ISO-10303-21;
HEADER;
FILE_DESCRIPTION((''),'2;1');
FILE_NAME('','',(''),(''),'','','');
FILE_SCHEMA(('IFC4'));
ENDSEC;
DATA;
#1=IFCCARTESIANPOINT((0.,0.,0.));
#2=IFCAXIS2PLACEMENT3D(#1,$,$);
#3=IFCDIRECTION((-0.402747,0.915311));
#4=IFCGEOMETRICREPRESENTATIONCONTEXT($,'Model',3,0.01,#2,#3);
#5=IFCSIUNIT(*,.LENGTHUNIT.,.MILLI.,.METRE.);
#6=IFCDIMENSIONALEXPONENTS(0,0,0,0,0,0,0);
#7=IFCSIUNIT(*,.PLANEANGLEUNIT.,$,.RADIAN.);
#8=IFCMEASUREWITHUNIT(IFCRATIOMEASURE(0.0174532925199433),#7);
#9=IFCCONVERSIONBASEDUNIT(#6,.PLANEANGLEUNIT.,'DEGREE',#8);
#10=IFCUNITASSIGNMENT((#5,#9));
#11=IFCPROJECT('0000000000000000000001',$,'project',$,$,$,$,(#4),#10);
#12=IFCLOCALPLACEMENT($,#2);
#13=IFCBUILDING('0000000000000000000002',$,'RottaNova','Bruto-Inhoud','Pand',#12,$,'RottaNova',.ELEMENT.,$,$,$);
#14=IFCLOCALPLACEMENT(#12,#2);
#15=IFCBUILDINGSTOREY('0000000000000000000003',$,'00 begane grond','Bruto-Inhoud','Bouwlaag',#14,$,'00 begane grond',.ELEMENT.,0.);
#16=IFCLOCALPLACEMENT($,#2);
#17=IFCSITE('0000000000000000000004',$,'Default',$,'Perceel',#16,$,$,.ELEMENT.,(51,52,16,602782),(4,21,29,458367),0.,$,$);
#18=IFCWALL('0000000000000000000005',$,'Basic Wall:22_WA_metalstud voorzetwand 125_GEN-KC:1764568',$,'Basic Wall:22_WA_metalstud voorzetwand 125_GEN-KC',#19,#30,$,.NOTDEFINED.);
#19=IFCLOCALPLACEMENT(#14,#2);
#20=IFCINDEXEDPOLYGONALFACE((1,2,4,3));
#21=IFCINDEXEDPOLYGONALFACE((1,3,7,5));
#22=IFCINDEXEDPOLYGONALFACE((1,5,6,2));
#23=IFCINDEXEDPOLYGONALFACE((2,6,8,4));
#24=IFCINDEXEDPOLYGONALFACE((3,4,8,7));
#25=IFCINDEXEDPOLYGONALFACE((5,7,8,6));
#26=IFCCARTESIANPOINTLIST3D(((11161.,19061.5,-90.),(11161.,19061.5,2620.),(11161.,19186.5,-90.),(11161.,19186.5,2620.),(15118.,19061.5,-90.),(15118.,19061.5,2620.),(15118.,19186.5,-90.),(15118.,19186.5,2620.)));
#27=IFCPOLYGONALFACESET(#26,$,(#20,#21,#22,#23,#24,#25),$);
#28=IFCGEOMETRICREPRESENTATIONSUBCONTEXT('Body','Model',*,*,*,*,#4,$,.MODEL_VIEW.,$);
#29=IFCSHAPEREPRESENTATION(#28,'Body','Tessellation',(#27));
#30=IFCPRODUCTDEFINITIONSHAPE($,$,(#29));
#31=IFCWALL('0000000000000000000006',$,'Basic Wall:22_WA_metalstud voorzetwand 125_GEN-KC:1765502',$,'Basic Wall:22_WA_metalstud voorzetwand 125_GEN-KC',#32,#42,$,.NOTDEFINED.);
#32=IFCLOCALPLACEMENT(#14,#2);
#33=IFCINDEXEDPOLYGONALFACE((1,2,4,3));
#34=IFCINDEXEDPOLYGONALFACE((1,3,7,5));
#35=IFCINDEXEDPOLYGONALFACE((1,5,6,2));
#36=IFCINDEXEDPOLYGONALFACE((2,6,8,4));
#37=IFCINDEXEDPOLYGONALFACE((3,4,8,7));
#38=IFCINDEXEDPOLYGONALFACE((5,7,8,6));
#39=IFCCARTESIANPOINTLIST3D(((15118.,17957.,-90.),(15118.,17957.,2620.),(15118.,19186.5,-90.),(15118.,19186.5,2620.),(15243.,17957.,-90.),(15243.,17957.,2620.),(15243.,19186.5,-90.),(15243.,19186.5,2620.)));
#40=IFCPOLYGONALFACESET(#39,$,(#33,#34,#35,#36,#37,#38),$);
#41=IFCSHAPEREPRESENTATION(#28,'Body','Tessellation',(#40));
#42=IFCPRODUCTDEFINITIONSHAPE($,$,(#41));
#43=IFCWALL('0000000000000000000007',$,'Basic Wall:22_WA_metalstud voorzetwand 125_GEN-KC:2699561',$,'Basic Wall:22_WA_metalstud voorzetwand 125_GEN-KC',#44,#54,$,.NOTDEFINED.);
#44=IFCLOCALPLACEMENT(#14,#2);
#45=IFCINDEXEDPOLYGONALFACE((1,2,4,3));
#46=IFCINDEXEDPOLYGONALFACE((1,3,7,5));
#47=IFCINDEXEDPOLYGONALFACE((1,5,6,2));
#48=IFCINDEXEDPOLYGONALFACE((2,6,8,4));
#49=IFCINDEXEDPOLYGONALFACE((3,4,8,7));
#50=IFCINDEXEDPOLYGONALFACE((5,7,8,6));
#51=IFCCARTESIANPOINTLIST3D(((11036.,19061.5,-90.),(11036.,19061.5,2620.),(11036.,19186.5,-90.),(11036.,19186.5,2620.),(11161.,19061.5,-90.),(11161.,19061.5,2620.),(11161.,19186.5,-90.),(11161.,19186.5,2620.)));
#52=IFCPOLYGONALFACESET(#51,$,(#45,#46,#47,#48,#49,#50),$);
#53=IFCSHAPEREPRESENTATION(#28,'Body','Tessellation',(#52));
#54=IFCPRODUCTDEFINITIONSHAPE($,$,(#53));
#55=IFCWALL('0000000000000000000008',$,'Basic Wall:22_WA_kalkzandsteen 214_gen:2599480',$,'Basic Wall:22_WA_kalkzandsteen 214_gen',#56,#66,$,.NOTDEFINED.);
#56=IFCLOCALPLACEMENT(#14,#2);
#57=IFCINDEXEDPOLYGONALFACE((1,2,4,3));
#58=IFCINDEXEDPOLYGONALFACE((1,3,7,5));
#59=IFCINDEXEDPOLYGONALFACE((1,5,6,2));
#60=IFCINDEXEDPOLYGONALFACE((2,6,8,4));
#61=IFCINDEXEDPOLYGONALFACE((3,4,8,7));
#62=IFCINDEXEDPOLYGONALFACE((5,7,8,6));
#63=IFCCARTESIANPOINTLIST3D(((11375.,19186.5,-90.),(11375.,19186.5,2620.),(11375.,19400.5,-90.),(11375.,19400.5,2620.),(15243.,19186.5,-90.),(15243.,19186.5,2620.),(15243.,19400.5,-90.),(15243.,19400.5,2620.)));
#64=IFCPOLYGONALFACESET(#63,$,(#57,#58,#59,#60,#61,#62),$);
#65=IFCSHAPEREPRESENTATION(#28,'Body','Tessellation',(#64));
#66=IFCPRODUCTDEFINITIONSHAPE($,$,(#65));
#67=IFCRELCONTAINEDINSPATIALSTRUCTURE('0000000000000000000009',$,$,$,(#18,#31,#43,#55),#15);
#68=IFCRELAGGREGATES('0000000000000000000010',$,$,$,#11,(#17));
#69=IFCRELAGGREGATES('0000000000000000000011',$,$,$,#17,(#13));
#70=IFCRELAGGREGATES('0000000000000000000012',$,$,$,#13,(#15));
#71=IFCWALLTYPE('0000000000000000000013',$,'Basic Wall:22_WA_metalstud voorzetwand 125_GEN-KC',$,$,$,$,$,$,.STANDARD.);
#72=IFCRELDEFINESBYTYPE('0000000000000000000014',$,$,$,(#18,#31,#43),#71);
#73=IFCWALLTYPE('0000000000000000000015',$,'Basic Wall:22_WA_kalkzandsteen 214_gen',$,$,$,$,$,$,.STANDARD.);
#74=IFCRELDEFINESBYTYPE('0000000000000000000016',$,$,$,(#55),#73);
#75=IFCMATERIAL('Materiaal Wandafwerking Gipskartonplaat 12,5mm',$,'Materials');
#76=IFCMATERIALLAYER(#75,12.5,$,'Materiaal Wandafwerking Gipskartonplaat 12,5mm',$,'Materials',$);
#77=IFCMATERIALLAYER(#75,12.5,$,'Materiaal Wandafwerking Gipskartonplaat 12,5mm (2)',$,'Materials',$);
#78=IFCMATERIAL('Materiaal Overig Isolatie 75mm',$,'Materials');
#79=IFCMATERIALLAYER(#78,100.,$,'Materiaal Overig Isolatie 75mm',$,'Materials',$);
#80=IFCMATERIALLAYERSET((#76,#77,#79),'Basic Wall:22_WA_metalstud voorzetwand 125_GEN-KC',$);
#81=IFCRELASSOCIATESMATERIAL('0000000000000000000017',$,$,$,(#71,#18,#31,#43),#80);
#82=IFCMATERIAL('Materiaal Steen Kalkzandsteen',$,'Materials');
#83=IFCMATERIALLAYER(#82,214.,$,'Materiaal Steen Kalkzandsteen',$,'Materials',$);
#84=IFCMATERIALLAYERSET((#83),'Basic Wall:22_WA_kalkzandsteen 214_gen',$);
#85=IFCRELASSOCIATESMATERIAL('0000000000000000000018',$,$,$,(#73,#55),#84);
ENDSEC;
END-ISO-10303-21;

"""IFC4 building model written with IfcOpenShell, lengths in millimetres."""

from ifc_helpers import new_model, entity, si_unit, converted_unit, direction, frame, frame_2d, origin, place, context, subcontext, project, spatial, rectangle, extrude, material, layer, layer_set, type_object, element, save


model = new_model("IFC4")

# Units and contexts
model_context = context("Model", 3, precision=0.01, world=origin(), true_north=direction((-0.402747, 0.915311)))
body_context = subcontext(model_context, "Body", "Model", "MODEL_VIEW")
ifc_project = project(units=[si_unit("LENGTHUNIT", "METRE", prefix="MILLI"), converted_unit("PLANEANGLEUNIT", "DEGREE", entity("IfcRatioMeasure", 0.0174532925199433), si_unit("PLANEANGLEUNIT", "RADIAN"), dimensions=[0, 0, 0, 0, 0, 0, 0])], contexts=[model_context])

# Site, building, storey
site_placement = place(None, origin())
site = spatial("IfcSite", under=ifc_project, at=site_placement, Name="Default", ObjectType="Perceel", CompositionType="ELEMENT", RefLatitude=(51, 52, 16, 602782), RefLongitude=(4, 21, 29, 458367), RefElevation=0.0)
building_placement = place(None, origin())
building = spatial("IfcBuilding", under=site, at=building_placement, Name="RottaNova", Description="Bruto-Inhoud", ObjectType="Pand", LongName="RottaNova", CompositionType="ELEMENT")
storey_placement = place(building_placement, origin())
storey = spatial("IfcBuildingStorey", under=building, at=storey_placement, Name="00 begane grond", Description="Bruto-Inhoud", ObjectType="Bouwlaag", LongName="00 begane grond", CompositionType="ELEMENT", Elevation=0.0)

# Shared definitions
ifc_material_1 = material(Name="Materiaal Steen Kalkzandsteen", Category="Materials")

# Shared definitions
ifc_material_2 = material(Name="Materiaal Wandafwerking Gipskartonplaat 12,5mm", Category="Materials")

# Walls
ifc_layer_1 = layer(ifc_material_2, 12.5, Name="Materiaal Wandafwerking Gipskartonplaat 12,5mm", Category="Materials")
ifc_layer_2 = layer(ifc_material_2, 12.5, Name="Materiaal Wandafwerking Gipskartonplaat 12,5mm (2)", Category="Materials")
ifc_material_3 = material(Name="Materiaal Overig Isolatie 75mm", Category="Materials")
ifc_layer_3 = layer(ifc_material_3, 100.0, Name="Materiaal Overig Isolatie 75mm", Category="Materials")
ifc_layer_set_1 = layer_set([ifc_layer_1, ifc_layer_2, ifc_layer_3], Name="Basic Wall:22_WA_metalstud voorzetwand 125_GEN-KC")
wall_type_1 = type_object("IfcWallType", Name="Basic Wall:22_WA_metalstud voorzetwand 125_GEN-KC", PredefinedType="STANDARD", material=ifc_layer_set_1)
wall_1_placement = place(storey_placement, frame((11161.0, 19124.0, -90.0)))
element("IfcWall", 1, at=wall_1_placement, inside=storey, type_object=wall_type_1, material=ifc_layer_set_1, Name="Basic Wall:22_WA_metalstud voorzetwand 125_GEN-KC:1764568", ObjectType="Basic Wall:22_WA_metalstud voorzetwand 125_GEN-KC", PredefinedType="NOTDEFINED", context=body_context, shape_type="SweptSolid", body=[
    extrude(rectangle(XDim=3957.0, YDim=125.0, at=frame_2d((1978.5, 0.0), x_axis=(-1.0, 0.0))), origin(), (0.0, 0.0, 1.0), 2710.0),
])
wall_2_placement = place(storey_placement, frame((15180.5, 17957.0, -90.0), z_axis=(0.0, 0.0, 1.0), x_axis=(0.0, 1.0, 0.0)))
element("IfcWall", 2, at=wall_2_placement, inside=storey, type_object=wall_type_1, material=ifc_layer_set_1, Name="Basic Wall:22_WA_metalstud voorzetwand 125_GEN-KC:1765502", ObjectType="Basic Wall:22_WA_metalstud voorzetwand 125_GEN-KC", PredefinedType="NOTDEFINED", context=body_context, shape_type="SweptSolid", body=[
    extrude(rectangle(XDim=1229.5, YDim=125.0, at=frame_2d((614.8, 0.0), x_axis=(-1.0, 0.0))), origin(), (0.0, 0.0, 1.0), 2710.0),
])
wall_3_placement = place(storey_placement, frame((11098.5, 19061.5, -90.0), z_axis=(0.0, 0.0, 1.0), x_axis=(0.0, 1.0, 0.0)))
element("IfcWall", 3, at=wall_3_placement, inside=storey, type_object=wall_type_1, material=ifc_layer_set_1, Name="Basic Wall:22_WA_metalstud voorzetwand 125_GEN-KC:2699561", ObjectType="Basic Wall:22_WA_metalstud voorzetwand 125_GEN-KC", PredefinedType="NOTDEFINED", context=body_context, shape_type="SweptSolid", body=[
    extrude(rectangle(XDim=125.0, YDim=125.0, at=frame_2d((62.5, 0.0), x_axis=(-1.0, 0.0))), origin(), (0.0, 0.0, 1.0), 2710.0),
])
ifc_layer_4 = layer(ifc_material_1, 214.0, Name="Materiaal Steen Kalkzandsteen", Category="Materials")
ifc_layer_set_2 = layer_set([ifc_layer_4], Name="Basic Wall:22_WA_kalkzandsteen 214_gen")
wall_type_2 = type_object("IfcWallType", Name="Basic Wall:22_WA_kalkzandsteen 214_gen", PredefinedType="STANDARD", material=ifc_layer_set_2)
wall_4_placement = place(storey_placement, frame((11375.0, 19293.5, -90.0)))
element("IfcWall", 4, at=wall_4_placement, inside=storey, type_object=wall_type_2, material=ifc_layer_set_2, Name="Basic Wall:22_WA_kalkzandsteen 214_gen:2599480", ObjectType="Basic Wall:22_WA_kalkzandsteen 214_gen", PredefinedType="NOTDEFINED", context=body_context, shape_type="SweptSolid", body=[
    extrude(rectangle(XDim=3868.0, YDim=214.0, at=frame_2d((1934.0, 0.0), x_axis=(-1.0, 0.0))), origin(), (0.0, 0.0, 1.0), 2710.0),
])

save(model, "model.ifc")
